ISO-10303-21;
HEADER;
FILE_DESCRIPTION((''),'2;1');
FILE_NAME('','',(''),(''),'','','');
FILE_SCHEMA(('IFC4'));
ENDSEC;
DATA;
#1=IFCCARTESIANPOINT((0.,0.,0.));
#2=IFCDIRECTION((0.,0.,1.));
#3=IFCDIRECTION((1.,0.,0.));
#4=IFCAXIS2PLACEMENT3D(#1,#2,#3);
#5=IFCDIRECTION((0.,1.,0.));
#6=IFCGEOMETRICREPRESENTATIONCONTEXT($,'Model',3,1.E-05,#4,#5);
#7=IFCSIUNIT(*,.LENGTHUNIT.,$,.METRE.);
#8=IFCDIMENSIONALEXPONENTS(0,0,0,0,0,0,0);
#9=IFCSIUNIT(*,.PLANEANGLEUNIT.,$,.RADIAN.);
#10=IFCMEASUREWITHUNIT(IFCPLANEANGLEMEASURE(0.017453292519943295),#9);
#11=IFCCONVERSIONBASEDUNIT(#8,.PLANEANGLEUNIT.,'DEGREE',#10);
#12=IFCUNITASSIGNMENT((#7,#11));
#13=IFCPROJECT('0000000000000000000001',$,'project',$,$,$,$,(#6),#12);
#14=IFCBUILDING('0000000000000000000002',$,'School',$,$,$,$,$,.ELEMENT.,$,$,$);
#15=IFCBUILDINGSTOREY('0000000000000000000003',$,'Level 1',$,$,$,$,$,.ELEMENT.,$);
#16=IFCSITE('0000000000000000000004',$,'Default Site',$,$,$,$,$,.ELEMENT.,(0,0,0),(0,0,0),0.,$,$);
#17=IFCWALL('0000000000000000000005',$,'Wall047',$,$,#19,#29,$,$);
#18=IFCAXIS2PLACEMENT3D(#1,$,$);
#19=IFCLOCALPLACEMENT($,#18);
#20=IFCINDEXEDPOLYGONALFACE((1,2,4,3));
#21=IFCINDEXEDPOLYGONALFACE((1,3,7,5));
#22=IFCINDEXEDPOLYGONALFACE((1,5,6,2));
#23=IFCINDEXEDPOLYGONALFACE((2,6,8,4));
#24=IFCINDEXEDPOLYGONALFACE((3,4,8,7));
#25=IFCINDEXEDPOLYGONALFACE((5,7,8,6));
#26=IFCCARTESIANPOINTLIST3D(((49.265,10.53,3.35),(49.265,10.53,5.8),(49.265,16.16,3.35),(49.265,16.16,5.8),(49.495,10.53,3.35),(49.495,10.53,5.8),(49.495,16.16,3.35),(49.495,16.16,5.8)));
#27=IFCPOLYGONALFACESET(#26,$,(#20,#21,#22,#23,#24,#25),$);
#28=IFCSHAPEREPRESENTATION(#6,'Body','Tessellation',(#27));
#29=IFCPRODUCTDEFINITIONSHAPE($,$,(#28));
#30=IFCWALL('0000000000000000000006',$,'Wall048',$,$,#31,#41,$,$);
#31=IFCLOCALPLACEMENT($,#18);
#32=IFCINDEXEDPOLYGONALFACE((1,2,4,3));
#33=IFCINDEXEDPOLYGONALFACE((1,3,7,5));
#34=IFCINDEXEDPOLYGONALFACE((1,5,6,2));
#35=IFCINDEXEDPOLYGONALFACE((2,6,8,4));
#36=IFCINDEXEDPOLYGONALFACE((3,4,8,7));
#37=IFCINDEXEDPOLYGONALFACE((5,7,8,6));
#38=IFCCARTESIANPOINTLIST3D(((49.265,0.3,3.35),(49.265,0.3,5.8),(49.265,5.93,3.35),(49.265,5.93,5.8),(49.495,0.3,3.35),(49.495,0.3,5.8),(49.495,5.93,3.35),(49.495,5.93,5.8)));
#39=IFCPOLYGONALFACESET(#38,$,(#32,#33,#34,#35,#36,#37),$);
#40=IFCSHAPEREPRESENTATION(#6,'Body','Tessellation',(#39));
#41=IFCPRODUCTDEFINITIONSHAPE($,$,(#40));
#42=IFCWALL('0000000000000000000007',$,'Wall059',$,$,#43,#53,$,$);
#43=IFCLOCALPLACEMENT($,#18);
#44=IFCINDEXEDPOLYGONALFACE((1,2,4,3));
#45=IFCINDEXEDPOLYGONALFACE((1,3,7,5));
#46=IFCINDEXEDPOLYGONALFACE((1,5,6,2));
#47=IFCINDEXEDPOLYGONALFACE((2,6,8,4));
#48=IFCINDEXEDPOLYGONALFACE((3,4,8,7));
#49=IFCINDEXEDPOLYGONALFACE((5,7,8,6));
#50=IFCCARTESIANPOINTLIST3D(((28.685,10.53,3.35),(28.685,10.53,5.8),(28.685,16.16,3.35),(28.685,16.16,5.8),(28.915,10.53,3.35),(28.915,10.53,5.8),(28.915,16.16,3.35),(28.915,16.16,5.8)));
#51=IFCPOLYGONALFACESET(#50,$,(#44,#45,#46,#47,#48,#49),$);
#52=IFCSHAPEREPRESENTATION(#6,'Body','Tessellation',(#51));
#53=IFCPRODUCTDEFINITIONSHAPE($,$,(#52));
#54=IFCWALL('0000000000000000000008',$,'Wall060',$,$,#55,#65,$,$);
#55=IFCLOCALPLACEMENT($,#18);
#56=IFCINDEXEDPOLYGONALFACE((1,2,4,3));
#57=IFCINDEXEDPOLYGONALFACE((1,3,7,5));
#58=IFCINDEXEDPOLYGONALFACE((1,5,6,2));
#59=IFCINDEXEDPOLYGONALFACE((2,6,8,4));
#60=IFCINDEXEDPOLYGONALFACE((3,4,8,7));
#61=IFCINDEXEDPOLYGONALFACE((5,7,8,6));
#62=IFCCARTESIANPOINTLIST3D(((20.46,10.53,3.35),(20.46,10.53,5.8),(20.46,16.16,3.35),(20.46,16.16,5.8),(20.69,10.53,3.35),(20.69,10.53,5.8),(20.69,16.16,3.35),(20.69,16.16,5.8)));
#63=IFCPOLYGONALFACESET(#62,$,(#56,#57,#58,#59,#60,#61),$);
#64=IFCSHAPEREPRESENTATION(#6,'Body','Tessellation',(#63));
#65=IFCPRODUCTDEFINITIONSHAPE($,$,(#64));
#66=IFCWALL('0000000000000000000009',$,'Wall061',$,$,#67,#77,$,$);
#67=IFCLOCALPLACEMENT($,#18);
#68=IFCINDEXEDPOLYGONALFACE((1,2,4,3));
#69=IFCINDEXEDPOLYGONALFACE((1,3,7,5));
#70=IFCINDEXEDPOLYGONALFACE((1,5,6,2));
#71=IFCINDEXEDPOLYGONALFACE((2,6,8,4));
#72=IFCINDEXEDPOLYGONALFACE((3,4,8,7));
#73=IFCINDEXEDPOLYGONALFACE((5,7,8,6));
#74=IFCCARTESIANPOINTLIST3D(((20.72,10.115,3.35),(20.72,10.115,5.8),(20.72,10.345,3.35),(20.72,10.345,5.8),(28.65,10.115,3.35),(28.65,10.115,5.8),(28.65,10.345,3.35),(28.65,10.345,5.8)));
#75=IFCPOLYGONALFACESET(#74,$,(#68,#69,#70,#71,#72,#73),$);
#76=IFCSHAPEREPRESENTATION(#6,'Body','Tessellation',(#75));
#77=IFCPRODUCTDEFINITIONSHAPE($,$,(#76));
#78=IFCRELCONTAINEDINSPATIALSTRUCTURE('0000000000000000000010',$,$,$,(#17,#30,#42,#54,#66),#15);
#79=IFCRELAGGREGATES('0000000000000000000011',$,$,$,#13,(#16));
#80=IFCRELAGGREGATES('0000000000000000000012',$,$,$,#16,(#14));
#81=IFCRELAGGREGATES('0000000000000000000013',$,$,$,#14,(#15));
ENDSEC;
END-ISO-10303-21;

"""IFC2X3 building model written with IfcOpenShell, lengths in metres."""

from ifc_helpers import new_model, entity, si_unit, converted_unit, direction, frame, frame_2d, origin_with_axes, place, context, project, spatial, rectangle, extrude, element, save


model = new_model("IFC2X3")

# Units and contexts
model_context = context("Model", 3, precision=1e-05, world=origin_with_axes(), true_north=direction((0.0, 1.0, 0.0)))
ifc_project = project(units=[si_unit("LENGTHUNIT", "METRE"), converted_unit("PLANEANGLEUNIT", "DEGREE", entity("IfcPlaneAngleMeasure", 0.017453292519943295), si_unit("PLANEANGLEUNIT", "RADIAN"), dimensions=[0, 0, 0, 0, 0, 0, 0])], contexts=[model_context])

# Site, building, storey
site = spatial("IfcSite", under=ifc_project, Name="Default Site", CompositionType="ELEMENT", RefLatitude=(0, 0, 0), RefLongitude=(0, 0, 0), RefElevation=0.0)
building = spatial("IfcBuilding", under=site, Name="School", CompositionType="ELEMENT")
storey = spatial("IfcBuildingStorey", under=building, Name="Level 1", CompositionType="ELEMENT")

# Shared definitions
placement = place(None, origin_with_axes())

# Walls
element("IfcWall", 1, at=placement, inside=storey, Name="Wall047", context=model_context, shape_type="SweptSolid", body=[
    extrude(rectangle(XDim=5.63, YDim=0.23, at=frame_2d((0.0, 0.0), x_axis=(0.0, 1.0, 0.0))), frame((49.38, 13.345, 3.35), z_axis=(0.0, 0.0, 1.0), x_axis=(1.0, 0.0, 0.0)), (0.0, 0.0, 1.0), 2.45),
])
element("IfcWall", 2, at=placement, inside=storey, Name="Wall048", context=model_context, shape_type="SweptSolid", body=[
    extrude(rectangle(XDim=5.63, YDim=0.23, at=frame_2d((0.0, 0.0), x_axis=(0.0, 1.0, 0.0))), frame((49.38, 3.115, 3.35), z_axis=(0.0, 0.0, 1.0), x_axis=(1.0, 0.0, 0.0)), (0.0, 0.0, 1.0), 2.45),
])
element("IfcWall", 3, at=placement, inside=storey, Name="Wall059", context=model_context, shape_type="SweptSolid", body=[
    extrude(rectangle(XDim=5.63, YDim=0.23, at=frame_2d((0.0, 0.0), x_axis=(0.0, 1.0, 0.0))), frame((28.8, 13.345, 3.35), z_axis=(0.0, 0.0, 1.0), x_axis=(1.0, 0.0, 0.0)), (0.0, 0.0, 1.0), 2.45),
])
element("IfcWall", 4, at=placement, inside=storey, Name="Wall060", context=model_context, shape_type="SweptSolid", body=[
    extrude(rectangle(XDim=5.63, YDim=0.23, at=frame_2d((0.0, 0.0), x_axis=(0.0, 1.0, 0.0))), frame((20.575, 13.345, 3.35), z_axis=(0.0, 0.0, 1.0), x_axis=(1.0, 0.0, 0.0)), (0.0, 0.0, 1.0), 2.45),
])
element("IfcWall", 5, at=placement, inside=storey, Name="Wall061", context=model_context, shape_type="SweptSolid", body=[
    extrude(rectangle(XDim=7.93, YDim=0.23, at=frame_2d((0.0, 0.0), x_axis=(1.0, 0.0, 0.0))), frame((24.685, 10.23, 3.35), z_axis=(0.0, 0.0, 1.0), x_axis=(1.0, 0.0, 0.0)), (0.0, 0.0, 1.0), 2.45),
])

save(model, "model.ifc")
